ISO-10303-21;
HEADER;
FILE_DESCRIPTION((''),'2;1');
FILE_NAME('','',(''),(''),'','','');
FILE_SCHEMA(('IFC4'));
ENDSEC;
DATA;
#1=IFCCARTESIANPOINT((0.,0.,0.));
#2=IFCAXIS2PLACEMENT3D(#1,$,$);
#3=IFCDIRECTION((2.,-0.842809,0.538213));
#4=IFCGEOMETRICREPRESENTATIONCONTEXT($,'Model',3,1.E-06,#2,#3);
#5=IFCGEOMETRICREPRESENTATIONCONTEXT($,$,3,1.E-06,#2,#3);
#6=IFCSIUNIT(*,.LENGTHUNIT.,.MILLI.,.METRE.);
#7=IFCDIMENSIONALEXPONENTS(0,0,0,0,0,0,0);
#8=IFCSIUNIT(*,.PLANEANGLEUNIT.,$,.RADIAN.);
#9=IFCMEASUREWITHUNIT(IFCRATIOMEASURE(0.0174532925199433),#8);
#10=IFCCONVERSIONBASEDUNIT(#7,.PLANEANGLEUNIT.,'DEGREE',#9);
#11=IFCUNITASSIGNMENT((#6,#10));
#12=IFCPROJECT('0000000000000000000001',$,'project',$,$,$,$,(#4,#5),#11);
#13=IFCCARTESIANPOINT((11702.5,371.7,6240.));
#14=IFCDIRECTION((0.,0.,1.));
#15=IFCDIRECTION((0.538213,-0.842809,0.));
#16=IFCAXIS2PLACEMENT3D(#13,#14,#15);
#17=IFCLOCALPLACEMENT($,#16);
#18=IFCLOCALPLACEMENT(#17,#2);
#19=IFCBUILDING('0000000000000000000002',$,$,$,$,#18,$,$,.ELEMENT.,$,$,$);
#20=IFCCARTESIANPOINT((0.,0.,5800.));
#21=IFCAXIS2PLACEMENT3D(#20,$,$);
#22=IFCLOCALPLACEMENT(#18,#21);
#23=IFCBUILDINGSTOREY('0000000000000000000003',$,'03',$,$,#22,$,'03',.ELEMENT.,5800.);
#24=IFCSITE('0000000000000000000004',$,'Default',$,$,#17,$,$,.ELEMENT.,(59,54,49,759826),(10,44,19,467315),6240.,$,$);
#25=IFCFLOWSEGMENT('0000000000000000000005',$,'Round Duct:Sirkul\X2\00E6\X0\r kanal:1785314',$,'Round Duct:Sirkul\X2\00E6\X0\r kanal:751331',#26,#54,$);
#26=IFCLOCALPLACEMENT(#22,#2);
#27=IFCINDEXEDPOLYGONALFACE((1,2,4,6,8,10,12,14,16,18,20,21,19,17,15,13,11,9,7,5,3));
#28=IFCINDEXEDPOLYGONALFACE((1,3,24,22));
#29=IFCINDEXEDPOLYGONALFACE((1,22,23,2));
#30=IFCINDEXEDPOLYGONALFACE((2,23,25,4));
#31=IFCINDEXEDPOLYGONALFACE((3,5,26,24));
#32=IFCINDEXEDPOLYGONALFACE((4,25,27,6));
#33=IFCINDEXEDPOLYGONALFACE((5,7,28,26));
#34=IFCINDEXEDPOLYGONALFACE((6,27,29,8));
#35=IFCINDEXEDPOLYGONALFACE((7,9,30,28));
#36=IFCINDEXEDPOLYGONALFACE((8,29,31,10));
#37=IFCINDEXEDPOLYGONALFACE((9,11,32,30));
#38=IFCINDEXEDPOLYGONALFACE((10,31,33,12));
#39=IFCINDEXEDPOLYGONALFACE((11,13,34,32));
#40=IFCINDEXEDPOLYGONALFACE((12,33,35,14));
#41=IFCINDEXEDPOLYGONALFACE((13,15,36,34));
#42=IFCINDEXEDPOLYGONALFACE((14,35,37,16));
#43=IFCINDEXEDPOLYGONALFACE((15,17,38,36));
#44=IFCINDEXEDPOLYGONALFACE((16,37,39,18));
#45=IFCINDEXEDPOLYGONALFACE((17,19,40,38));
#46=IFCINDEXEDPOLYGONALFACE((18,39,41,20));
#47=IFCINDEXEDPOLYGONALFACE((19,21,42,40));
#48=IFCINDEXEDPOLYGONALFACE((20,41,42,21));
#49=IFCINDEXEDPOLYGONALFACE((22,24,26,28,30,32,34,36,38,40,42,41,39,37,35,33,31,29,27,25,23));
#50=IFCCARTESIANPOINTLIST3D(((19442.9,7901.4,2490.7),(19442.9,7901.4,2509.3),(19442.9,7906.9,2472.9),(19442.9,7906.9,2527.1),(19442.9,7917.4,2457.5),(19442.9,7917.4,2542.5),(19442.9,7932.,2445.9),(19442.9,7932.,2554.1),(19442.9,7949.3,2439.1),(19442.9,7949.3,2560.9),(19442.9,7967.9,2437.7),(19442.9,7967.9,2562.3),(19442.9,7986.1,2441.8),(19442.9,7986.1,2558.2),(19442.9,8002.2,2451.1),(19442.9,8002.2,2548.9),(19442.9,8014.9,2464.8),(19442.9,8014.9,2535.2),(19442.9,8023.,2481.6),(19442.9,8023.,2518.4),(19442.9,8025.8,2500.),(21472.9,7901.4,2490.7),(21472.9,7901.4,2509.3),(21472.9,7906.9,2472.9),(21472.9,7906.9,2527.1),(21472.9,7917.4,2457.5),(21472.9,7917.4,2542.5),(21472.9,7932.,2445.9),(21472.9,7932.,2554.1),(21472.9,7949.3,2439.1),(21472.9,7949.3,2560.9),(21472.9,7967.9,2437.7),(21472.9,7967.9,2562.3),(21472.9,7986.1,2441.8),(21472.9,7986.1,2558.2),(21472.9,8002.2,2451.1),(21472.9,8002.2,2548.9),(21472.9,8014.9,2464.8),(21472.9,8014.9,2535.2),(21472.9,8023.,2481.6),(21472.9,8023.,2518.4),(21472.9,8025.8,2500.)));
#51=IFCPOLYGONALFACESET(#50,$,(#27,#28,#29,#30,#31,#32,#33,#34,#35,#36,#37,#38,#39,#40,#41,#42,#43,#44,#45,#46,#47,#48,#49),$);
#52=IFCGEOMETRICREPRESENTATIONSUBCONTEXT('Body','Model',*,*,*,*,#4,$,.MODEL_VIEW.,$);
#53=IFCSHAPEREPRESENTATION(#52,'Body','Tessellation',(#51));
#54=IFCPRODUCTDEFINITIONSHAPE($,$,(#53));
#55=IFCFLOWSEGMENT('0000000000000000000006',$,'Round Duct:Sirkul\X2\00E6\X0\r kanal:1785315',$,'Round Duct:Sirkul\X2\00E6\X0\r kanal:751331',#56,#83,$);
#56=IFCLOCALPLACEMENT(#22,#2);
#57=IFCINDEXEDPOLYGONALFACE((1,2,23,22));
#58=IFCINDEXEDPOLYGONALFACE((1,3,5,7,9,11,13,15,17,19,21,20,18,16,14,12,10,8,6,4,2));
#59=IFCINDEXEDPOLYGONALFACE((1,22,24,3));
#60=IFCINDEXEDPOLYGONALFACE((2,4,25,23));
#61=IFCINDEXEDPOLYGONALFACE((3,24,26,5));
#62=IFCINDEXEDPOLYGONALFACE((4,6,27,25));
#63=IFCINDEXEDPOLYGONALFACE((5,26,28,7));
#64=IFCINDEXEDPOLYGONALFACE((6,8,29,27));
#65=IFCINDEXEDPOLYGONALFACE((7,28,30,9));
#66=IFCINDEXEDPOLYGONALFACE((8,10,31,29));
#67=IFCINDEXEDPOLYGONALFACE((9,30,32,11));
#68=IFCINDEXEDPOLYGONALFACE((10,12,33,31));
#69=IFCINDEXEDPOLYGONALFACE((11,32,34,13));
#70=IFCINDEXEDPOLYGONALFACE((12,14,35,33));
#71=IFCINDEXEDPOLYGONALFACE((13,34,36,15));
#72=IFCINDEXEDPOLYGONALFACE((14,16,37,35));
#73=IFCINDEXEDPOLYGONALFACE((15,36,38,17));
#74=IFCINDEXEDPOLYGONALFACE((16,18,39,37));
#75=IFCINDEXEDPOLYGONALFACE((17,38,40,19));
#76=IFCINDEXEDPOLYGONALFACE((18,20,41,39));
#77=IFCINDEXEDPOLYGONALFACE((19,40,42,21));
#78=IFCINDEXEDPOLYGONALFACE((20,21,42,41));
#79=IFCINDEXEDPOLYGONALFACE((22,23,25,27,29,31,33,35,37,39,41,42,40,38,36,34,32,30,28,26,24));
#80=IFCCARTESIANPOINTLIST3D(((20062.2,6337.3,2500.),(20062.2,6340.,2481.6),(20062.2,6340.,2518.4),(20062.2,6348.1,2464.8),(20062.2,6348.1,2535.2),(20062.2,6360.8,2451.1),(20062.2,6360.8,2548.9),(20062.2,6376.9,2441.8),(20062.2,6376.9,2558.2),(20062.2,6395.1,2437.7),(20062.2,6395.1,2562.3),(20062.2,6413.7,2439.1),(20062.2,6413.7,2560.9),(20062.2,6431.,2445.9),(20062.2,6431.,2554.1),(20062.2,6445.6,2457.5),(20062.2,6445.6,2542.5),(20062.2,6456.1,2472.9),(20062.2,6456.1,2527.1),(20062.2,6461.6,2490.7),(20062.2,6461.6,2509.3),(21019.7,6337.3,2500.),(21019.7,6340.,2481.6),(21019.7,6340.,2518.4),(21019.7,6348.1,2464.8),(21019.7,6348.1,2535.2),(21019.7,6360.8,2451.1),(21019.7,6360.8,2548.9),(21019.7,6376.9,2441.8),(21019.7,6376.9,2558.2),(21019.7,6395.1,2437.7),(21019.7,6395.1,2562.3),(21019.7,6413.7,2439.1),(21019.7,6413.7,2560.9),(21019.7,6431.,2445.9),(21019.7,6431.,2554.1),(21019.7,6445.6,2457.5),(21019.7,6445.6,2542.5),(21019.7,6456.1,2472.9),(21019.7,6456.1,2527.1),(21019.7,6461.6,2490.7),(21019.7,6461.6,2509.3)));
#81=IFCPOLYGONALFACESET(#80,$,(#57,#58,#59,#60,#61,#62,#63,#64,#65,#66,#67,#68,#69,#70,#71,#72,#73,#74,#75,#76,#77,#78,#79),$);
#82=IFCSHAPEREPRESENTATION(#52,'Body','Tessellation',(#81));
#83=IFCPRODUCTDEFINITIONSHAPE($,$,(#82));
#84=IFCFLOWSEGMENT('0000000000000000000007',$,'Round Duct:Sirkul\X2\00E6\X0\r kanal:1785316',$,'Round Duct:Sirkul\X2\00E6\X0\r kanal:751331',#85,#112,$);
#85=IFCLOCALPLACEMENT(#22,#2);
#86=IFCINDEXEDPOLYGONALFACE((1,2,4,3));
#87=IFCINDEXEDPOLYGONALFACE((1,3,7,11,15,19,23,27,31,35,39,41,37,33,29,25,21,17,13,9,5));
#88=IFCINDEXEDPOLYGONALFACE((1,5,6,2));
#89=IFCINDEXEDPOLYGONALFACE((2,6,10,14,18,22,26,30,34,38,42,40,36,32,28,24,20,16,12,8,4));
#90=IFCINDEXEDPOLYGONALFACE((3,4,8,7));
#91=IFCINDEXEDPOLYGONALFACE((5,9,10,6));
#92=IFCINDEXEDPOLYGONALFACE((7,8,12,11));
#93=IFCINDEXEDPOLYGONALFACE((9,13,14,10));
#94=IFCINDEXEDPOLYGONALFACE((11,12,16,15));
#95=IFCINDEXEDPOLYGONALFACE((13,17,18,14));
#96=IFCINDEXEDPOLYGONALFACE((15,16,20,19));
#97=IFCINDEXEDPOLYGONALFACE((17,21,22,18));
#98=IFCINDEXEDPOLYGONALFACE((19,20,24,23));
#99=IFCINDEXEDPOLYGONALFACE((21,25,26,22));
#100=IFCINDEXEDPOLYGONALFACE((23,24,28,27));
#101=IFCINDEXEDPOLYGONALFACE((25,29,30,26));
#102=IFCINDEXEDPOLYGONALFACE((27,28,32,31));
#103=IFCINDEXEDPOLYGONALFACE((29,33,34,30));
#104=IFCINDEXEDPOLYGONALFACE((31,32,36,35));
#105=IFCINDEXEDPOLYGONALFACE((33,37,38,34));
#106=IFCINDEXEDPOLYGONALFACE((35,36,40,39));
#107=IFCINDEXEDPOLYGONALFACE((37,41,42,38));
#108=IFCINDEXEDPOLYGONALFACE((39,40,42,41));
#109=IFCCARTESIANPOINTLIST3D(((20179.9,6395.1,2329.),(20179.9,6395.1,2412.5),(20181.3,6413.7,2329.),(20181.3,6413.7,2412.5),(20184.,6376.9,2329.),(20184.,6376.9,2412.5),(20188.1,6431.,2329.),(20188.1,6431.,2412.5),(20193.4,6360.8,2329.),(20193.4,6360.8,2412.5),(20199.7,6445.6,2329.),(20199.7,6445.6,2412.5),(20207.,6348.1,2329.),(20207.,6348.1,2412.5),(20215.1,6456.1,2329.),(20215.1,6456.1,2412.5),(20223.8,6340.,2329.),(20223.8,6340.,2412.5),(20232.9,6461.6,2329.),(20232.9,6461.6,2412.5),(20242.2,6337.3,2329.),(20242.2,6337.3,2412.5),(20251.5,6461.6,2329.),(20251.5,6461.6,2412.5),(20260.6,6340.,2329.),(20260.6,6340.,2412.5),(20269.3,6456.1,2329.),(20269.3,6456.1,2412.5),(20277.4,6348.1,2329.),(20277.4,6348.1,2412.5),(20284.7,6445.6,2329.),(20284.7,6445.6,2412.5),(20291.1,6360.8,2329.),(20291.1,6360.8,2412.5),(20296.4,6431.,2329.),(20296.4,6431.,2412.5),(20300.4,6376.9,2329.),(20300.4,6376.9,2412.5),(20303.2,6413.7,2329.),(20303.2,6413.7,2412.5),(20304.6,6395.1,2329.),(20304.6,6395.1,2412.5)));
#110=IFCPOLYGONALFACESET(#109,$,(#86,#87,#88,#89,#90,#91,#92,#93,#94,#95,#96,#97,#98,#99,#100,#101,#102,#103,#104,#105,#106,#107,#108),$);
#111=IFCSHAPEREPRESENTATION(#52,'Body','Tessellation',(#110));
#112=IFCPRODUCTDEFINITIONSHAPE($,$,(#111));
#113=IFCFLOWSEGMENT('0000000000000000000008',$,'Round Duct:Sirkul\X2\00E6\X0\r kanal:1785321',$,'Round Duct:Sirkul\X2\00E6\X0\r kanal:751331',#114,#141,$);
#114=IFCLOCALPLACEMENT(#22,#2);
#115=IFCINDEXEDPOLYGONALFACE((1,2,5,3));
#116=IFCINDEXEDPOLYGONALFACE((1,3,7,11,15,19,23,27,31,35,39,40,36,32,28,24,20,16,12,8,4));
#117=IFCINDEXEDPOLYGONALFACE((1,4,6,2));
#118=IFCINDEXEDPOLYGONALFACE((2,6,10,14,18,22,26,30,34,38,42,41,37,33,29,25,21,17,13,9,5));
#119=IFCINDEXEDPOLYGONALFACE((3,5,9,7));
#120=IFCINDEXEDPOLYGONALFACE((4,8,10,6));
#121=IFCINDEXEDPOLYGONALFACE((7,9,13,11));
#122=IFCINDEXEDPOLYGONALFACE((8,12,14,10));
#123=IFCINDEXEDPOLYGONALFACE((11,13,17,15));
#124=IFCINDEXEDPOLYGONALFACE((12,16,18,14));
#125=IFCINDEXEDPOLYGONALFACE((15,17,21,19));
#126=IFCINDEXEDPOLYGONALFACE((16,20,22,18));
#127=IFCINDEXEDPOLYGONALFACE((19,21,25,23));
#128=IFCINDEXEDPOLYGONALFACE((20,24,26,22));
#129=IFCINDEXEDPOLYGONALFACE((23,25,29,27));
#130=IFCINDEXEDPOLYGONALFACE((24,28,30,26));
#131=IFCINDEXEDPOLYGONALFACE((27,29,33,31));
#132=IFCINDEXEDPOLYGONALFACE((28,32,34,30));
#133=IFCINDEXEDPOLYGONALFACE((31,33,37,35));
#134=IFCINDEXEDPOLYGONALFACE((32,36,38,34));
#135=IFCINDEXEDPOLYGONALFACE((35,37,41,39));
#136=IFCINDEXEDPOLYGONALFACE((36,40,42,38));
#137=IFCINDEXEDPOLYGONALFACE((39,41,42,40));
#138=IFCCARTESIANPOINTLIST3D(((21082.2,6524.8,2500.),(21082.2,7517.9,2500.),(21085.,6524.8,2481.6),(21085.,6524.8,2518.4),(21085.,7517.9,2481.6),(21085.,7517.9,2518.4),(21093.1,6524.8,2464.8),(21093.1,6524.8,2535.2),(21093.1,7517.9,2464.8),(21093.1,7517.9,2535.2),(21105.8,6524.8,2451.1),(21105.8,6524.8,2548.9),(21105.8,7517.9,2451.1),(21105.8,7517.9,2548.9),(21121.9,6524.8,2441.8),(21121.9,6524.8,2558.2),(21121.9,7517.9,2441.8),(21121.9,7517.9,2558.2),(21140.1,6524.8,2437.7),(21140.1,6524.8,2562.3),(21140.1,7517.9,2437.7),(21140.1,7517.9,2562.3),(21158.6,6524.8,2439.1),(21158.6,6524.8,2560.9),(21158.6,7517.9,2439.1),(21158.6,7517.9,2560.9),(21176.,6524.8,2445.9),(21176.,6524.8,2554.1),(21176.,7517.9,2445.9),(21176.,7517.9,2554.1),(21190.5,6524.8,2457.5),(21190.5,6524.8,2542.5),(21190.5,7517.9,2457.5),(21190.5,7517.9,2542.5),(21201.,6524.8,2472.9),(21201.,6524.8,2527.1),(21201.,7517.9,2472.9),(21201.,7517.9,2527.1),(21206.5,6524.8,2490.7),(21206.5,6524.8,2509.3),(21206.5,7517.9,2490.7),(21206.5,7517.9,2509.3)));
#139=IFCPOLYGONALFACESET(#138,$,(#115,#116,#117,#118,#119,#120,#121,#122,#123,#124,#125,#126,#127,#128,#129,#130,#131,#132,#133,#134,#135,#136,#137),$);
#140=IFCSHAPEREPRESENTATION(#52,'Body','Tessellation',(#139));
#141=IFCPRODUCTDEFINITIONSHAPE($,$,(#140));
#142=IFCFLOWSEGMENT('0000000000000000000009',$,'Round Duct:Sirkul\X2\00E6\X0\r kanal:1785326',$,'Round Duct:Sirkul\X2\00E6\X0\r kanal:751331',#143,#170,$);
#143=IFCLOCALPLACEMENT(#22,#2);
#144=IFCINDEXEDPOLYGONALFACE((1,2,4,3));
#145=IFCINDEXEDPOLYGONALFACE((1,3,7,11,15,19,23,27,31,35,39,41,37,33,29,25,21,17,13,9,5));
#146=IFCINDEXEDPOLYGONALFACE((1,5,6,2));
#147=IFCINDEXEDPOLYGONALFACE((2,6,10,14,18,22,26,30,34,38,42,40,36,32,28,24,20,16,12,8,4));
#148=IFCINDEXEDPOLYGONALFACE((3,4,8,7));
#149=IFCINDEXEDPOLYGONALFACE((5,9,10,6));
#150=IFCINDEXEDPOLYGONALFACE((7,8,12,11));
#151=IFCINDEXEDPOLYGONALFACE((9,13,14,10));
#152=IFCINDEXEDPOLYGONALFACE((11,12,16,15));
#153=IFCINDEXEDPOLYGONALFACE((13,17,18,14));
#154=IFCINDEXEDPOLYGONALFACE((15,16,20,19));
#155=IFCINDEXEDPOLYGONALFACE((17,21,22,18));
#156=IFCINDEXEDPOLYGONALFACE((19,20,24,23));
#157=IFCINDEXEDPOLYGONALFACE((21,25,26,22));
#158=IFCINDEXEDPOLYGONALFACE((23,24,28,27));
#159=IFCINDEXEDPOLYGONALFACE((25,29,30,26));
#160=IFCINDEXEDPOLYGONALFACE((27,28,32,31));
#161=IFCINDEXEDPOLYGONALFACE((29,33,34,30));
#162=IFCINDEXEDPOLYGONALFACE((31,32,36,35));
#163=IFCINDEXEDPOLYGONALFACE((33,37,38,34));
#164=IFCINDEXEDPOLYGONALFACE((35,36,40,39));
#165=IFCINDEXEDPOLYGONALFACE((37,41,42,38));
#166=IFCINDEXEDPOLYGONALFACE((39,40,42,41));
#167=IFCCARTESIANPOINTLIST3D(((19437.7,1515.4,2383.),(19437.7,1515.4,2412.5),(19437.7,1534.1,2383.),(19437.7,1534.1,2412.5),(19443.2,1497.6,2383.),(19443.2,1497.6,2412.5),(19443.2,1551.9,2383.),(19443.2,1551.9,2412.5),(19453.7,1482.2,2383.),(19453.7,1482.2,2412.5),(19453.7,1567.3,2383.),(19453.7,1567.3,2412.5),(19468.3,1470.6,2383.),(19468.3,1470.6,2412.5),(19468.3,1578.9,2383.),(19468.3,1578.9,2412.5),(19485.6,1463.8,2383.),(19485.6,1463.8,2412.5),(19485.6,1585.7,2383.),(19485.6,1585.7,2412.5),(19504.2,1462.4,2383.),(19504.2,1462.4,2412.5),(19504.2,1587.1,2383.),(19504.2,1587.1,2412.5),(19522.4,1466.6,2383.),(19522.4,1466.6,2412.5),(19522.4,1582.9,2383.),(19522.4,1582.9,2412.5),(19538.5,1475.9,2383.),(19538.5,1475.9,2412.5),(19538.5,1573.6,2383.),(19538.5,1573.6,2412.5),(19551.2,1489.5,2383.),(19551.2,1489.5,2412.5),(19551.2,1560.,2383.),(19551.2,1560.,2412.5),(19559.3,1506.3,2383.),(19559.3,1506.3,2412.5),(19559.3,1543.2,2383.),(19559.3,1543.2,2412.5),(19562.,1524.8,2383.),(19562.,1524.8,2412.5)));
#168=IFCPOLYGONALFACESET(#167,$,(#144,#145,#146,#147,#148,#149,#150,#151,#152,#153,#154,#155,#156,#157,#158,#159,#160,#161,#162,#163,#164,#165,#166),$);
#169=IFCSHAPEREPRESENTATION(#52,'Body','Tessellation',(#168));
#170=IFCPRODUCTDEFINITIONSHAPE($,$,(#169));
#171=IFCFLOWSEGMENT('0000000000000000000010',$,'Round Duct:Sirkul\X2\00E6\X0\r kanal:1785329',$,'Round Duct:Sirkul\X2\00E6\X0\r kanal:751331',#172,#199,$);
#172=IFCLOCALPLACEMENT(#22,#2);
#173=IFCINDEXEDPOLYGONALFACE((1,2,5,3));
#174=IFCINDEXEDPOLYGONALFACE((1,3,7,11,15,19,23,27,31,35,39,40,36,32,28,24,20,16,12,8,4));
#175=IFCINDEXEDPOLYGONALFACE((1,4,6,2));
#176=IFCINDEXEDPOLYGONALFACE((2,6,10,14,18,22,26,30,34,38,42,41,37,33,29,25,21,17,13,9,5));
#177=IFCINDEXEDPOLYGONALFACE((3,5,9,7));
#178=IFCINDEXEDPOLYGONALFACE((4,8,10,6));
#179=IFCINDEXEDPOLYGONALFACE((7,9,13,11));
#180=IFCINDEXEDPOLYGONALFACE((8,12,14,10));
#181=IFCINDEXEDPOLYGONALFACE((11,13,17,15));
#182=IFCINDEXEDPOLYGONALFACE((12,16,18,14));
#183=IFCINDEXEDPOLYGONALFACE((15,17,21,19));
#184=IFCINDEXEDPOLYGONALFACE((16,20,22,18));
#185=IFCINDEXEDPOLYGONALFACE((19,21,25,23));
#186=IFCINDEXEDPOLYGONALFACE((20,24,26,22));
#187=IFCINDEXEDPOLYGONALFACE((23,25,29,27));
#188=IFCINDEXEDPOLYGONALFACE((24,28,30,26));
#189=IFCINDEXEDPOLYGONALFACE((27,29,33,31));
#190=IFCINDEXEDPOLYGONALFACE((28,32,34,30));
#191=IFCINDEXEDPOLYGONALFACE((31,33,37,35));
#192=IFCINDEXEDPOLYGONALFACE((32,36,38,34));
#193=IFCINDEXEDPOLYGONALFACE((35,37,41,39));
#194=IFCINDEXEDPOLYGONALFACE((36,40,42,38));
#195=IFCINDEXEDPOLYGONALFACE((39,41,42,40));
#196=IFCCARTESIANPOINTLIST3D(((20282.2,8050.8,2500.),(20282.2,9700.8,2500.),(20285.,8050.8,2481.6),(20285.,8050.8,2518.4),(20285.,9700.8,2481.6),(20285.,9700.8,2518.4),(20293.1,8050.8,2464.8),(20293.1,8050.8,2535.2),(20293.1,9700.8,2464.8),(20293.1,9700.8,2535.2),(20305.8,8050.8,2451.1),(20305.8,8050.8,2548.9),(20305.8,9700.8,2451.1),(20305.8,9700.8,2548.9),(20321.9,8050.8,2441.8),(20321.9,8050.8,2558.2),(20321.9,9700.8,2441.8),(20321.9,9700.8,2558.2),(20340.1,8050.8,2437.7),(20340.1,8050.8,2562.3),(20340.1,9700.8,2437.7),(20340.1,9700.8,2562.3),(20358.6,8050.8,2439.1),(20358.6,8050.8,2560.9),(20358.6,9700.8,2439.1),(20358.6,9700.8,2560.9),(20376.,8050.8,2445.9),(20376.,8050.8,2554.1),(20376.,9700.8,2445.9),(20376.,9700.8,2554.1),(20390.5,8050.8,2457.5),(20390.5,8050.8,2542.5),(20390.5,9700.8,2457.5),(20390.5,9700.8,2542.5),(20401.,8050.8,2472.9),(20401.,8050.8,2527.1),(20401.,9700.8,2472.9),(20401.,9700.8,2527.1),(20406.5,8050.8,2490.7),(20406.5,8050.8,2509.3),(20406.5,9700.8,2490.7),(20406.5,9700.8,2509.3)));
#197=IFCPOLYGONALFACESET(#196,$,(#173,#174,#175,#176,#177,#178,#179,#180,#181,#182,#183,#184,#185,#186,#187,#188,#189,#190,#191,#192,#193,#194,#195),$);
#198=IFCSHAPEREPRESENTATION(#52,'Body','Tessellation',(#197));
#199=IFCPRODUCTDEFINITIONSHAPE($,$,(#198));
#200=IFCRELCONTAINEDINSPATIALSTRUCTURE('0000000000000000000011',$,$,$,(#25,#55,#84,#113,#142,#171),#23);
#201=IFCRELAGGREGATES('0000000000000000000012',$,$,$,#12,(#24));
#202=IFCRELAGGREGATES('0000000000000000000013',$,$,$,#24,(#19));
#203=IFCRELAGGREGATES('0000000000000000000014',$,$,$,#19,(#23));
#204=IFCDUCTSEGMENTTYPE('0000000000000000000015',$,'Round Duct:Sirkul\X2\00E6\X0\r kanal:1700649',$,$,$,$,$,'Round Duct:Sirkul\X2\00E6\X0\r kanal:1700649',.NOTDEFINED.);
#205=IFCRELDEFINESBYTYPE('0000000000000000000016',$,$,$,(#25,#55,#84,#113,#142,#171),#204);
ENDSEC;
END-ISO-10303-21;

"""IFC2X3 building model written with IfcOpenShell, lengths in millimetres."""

from ifc_helpers import new_model, entity, si_unit, converted_unit, direction, frame, frame_2d, origin, origin_2d_with_axis, place, context, subcontext, project, spatial, circle, extrude, type_object, element, save


model = new_model("IFC2X3")

# Units and contexts
model_context = context("Model", 3, precision=1e-06, world=origin(), true_north=direction((2.0, -0.842809, 0.538213)))
context_of_model = context(None, 3, precision=1e-06, world=origin(), true_north=direction((2.0, -0.842809, 0.538213)))
body_context = subcontext(model_context, "Body", "Model", "MODEL_VIEW")
ifc_project = project(units=[si_unit("LENGTHUNIT", "METRE", prefix="MILLI"), converted_unit("PLANEANGLEUNIT", "DEGREE", entity("IfcRatioMeasure", 0.0174532925199433), si_unit("PLANEANGLEUNIT", "RADIAN"), dimensions=[0, 0, 0, 0, 0, 0, 0])], contexts=[model_context, context_of_model])

# Site, building, storey
site_placement = place(None, frame((11702.5, 371.7, 6240.0), z_axis=(0.0, 0.0, 1.0), x_axis=(0.538213, -0.842809, 0.0)))
site = spatial("IfcSite", under=ifc_project, at=site_placement, Name="Default", CompositionType="ELEMENT", RefLatitude=(59, 54, 49, 759826), RefLongitude=(10, 44, 19, 467315), RefElevation=6240.0)
building_placement = place(site_placement, origin())
building = spatial("IfcBuilding", under=site, at=building_placement, CompositionType="ELEMENT")
storey_placement = place(building_placement, frame((0.0, 0.0, 5800.0)))
storey = spatial("IfcBuildingStorey", under=building, at=storey_placement, Name="03", LongName="03", CompositionType="ELEMENT", Elevation=5800.0)

# Flow segments
duct_segment_type = type_object("IfcDuctSegmentType", Name="Round Duct:Sirkulær kanal:1700649", ElementType="Round Duct:Sirkulær kanal:1700649", PredefinedType="NOTDEFINED")
flow_segment_1_placement = place(storey_placement, origin())
element("IfcFlowSegment", 1, at=flow_segment_1_placement, inside=storey, type_object=duct_segment_type, Name="Round Duct:Sirkulær kanal:1785314", ObjectType="Round Duct:Sirkulær kanal:751331", context=body_context, shape_type="SweptSolid", body=[
    extrude(circle(Radius=62.5, at=frame_2d((0.0, 0.0), x_axis=(1.0, 0.0))), frame((19442.9, 7963.3, 2500.0), z_axis=(1.0, 0.0, 0.0), x_axis=(0.0, 1.0, 0.0)), (0.0, 0.0, 1.0), 2030.0),
])
flow_segment_2_placement = place(storey_placement, origin())
element("IfcFlowSegment", 2, at=flow_segment_2_placement, inside=storey, type_object=duct_segment_type, Name="Round Duct:Sirkulær kanal:1785315", ObjectType="Round Duct:Sirkulær kanal:751331", context=body_context, shape_type="SweptSolid", body=[
    extrude(circle(Radius=62.5, at=origin_2d_with_axis()), frame((20062.2, 6399.8, 2500.0), z_axis=(1.0, 0.0, 0.0), x_axis=(0.0, -1.0, 0.0)), (0.0, 0.0, 1.0), 957.5),
])
flow_segment_3_placement = place(storey_placement, origin())
element("IfcFlowSegment", 3, at=flow_segment_3_placement, inside=storey, type_object=duct_segment_type, Name="Round Duct:Sirkulær kanal:1785316", ObjectType="Round Duct:Sirkulær kanal:751331", context=body_context, shape_type="SweptSolid", body=[
    extrude(circle(Radius=62.5, at=frame_2d((0.0, 0.0), x_axis=(1.0, 0.0))), frame((20242.2, 6399.8, 2329.0), z_axis=(0.0, 0.0, 1.0), x_axis=(0.0, -1.0, 0.0)), (0.0, 0.0, 1.0), 83.5),
])
flow_segment_4_placement = place(storey_placement, origin())
element("IfcFlowSegment", 4, at=flow_segment_4_placement, inside=storey, type_object=duct_segment_type, Name="Round Duct:Sirkulær kanal:1785321", ObjectType="Round Duct:Sirkulær kanal:751331", context=body_context, shape_type="SweptSolid", body=[
    extrude(circle(Radius=62.5, at=frame_2d((0.0, 0.0), x_axis=(1.0, 0.0))), frame((21144.7, 6524.8, 2500.0), z_axis=(0.0, 1.0, 0.0), x_axis=(-1.0, 0.0, 0.0)), (0.0, 0.0, 1.0), 993.1),
])
flow_segment_5_placement = place(storey_placement, origin())
element("IfcFlowSegment", 5, at=flow_segment_5_placement, inside=storey, type_object=duct_segment_type, Name="Round Duct:Sirkulær kanal:1785326", ObjectType="Round Duct:Sirkulær kanal:751331", context=body_context, shape_type="SweptSolid", body=[
    extrude(circle(Radius=62.5, at=frame_2d((0.0, 0.0), x_axis=(1.0, 0.0))), frame((19499.5, 1524.8, 2383.0)), (0.0, 0.0, 1.0), 29.5),
])
flow_segment_6_placement = place(storey_placement, origin())
element("IfcFlowSegment", 6, at=flow_segment_6_placement, inside=storey, type_object=duct_segment_type, Name="Round Duct:Sirkulær kanal:1785329", ObjectType="Round Duct:Sirkulær kanal:751331", context=body_context, shape_type="SweptSolid", body=[
    extrude(circle(Radius=62.5, at=frame_2d((0.0, 0.0), x_axis=(1.0, 0.0))), frame((20344.7, 8050.8, 2500.0), z_axis=(0.0, 1.0, 0.0), x_axis=(-1.0, 0.0, 0.0)), (0.0, 0.0, 1.0), 1650.0),
])

save(model, "model.ifc")
